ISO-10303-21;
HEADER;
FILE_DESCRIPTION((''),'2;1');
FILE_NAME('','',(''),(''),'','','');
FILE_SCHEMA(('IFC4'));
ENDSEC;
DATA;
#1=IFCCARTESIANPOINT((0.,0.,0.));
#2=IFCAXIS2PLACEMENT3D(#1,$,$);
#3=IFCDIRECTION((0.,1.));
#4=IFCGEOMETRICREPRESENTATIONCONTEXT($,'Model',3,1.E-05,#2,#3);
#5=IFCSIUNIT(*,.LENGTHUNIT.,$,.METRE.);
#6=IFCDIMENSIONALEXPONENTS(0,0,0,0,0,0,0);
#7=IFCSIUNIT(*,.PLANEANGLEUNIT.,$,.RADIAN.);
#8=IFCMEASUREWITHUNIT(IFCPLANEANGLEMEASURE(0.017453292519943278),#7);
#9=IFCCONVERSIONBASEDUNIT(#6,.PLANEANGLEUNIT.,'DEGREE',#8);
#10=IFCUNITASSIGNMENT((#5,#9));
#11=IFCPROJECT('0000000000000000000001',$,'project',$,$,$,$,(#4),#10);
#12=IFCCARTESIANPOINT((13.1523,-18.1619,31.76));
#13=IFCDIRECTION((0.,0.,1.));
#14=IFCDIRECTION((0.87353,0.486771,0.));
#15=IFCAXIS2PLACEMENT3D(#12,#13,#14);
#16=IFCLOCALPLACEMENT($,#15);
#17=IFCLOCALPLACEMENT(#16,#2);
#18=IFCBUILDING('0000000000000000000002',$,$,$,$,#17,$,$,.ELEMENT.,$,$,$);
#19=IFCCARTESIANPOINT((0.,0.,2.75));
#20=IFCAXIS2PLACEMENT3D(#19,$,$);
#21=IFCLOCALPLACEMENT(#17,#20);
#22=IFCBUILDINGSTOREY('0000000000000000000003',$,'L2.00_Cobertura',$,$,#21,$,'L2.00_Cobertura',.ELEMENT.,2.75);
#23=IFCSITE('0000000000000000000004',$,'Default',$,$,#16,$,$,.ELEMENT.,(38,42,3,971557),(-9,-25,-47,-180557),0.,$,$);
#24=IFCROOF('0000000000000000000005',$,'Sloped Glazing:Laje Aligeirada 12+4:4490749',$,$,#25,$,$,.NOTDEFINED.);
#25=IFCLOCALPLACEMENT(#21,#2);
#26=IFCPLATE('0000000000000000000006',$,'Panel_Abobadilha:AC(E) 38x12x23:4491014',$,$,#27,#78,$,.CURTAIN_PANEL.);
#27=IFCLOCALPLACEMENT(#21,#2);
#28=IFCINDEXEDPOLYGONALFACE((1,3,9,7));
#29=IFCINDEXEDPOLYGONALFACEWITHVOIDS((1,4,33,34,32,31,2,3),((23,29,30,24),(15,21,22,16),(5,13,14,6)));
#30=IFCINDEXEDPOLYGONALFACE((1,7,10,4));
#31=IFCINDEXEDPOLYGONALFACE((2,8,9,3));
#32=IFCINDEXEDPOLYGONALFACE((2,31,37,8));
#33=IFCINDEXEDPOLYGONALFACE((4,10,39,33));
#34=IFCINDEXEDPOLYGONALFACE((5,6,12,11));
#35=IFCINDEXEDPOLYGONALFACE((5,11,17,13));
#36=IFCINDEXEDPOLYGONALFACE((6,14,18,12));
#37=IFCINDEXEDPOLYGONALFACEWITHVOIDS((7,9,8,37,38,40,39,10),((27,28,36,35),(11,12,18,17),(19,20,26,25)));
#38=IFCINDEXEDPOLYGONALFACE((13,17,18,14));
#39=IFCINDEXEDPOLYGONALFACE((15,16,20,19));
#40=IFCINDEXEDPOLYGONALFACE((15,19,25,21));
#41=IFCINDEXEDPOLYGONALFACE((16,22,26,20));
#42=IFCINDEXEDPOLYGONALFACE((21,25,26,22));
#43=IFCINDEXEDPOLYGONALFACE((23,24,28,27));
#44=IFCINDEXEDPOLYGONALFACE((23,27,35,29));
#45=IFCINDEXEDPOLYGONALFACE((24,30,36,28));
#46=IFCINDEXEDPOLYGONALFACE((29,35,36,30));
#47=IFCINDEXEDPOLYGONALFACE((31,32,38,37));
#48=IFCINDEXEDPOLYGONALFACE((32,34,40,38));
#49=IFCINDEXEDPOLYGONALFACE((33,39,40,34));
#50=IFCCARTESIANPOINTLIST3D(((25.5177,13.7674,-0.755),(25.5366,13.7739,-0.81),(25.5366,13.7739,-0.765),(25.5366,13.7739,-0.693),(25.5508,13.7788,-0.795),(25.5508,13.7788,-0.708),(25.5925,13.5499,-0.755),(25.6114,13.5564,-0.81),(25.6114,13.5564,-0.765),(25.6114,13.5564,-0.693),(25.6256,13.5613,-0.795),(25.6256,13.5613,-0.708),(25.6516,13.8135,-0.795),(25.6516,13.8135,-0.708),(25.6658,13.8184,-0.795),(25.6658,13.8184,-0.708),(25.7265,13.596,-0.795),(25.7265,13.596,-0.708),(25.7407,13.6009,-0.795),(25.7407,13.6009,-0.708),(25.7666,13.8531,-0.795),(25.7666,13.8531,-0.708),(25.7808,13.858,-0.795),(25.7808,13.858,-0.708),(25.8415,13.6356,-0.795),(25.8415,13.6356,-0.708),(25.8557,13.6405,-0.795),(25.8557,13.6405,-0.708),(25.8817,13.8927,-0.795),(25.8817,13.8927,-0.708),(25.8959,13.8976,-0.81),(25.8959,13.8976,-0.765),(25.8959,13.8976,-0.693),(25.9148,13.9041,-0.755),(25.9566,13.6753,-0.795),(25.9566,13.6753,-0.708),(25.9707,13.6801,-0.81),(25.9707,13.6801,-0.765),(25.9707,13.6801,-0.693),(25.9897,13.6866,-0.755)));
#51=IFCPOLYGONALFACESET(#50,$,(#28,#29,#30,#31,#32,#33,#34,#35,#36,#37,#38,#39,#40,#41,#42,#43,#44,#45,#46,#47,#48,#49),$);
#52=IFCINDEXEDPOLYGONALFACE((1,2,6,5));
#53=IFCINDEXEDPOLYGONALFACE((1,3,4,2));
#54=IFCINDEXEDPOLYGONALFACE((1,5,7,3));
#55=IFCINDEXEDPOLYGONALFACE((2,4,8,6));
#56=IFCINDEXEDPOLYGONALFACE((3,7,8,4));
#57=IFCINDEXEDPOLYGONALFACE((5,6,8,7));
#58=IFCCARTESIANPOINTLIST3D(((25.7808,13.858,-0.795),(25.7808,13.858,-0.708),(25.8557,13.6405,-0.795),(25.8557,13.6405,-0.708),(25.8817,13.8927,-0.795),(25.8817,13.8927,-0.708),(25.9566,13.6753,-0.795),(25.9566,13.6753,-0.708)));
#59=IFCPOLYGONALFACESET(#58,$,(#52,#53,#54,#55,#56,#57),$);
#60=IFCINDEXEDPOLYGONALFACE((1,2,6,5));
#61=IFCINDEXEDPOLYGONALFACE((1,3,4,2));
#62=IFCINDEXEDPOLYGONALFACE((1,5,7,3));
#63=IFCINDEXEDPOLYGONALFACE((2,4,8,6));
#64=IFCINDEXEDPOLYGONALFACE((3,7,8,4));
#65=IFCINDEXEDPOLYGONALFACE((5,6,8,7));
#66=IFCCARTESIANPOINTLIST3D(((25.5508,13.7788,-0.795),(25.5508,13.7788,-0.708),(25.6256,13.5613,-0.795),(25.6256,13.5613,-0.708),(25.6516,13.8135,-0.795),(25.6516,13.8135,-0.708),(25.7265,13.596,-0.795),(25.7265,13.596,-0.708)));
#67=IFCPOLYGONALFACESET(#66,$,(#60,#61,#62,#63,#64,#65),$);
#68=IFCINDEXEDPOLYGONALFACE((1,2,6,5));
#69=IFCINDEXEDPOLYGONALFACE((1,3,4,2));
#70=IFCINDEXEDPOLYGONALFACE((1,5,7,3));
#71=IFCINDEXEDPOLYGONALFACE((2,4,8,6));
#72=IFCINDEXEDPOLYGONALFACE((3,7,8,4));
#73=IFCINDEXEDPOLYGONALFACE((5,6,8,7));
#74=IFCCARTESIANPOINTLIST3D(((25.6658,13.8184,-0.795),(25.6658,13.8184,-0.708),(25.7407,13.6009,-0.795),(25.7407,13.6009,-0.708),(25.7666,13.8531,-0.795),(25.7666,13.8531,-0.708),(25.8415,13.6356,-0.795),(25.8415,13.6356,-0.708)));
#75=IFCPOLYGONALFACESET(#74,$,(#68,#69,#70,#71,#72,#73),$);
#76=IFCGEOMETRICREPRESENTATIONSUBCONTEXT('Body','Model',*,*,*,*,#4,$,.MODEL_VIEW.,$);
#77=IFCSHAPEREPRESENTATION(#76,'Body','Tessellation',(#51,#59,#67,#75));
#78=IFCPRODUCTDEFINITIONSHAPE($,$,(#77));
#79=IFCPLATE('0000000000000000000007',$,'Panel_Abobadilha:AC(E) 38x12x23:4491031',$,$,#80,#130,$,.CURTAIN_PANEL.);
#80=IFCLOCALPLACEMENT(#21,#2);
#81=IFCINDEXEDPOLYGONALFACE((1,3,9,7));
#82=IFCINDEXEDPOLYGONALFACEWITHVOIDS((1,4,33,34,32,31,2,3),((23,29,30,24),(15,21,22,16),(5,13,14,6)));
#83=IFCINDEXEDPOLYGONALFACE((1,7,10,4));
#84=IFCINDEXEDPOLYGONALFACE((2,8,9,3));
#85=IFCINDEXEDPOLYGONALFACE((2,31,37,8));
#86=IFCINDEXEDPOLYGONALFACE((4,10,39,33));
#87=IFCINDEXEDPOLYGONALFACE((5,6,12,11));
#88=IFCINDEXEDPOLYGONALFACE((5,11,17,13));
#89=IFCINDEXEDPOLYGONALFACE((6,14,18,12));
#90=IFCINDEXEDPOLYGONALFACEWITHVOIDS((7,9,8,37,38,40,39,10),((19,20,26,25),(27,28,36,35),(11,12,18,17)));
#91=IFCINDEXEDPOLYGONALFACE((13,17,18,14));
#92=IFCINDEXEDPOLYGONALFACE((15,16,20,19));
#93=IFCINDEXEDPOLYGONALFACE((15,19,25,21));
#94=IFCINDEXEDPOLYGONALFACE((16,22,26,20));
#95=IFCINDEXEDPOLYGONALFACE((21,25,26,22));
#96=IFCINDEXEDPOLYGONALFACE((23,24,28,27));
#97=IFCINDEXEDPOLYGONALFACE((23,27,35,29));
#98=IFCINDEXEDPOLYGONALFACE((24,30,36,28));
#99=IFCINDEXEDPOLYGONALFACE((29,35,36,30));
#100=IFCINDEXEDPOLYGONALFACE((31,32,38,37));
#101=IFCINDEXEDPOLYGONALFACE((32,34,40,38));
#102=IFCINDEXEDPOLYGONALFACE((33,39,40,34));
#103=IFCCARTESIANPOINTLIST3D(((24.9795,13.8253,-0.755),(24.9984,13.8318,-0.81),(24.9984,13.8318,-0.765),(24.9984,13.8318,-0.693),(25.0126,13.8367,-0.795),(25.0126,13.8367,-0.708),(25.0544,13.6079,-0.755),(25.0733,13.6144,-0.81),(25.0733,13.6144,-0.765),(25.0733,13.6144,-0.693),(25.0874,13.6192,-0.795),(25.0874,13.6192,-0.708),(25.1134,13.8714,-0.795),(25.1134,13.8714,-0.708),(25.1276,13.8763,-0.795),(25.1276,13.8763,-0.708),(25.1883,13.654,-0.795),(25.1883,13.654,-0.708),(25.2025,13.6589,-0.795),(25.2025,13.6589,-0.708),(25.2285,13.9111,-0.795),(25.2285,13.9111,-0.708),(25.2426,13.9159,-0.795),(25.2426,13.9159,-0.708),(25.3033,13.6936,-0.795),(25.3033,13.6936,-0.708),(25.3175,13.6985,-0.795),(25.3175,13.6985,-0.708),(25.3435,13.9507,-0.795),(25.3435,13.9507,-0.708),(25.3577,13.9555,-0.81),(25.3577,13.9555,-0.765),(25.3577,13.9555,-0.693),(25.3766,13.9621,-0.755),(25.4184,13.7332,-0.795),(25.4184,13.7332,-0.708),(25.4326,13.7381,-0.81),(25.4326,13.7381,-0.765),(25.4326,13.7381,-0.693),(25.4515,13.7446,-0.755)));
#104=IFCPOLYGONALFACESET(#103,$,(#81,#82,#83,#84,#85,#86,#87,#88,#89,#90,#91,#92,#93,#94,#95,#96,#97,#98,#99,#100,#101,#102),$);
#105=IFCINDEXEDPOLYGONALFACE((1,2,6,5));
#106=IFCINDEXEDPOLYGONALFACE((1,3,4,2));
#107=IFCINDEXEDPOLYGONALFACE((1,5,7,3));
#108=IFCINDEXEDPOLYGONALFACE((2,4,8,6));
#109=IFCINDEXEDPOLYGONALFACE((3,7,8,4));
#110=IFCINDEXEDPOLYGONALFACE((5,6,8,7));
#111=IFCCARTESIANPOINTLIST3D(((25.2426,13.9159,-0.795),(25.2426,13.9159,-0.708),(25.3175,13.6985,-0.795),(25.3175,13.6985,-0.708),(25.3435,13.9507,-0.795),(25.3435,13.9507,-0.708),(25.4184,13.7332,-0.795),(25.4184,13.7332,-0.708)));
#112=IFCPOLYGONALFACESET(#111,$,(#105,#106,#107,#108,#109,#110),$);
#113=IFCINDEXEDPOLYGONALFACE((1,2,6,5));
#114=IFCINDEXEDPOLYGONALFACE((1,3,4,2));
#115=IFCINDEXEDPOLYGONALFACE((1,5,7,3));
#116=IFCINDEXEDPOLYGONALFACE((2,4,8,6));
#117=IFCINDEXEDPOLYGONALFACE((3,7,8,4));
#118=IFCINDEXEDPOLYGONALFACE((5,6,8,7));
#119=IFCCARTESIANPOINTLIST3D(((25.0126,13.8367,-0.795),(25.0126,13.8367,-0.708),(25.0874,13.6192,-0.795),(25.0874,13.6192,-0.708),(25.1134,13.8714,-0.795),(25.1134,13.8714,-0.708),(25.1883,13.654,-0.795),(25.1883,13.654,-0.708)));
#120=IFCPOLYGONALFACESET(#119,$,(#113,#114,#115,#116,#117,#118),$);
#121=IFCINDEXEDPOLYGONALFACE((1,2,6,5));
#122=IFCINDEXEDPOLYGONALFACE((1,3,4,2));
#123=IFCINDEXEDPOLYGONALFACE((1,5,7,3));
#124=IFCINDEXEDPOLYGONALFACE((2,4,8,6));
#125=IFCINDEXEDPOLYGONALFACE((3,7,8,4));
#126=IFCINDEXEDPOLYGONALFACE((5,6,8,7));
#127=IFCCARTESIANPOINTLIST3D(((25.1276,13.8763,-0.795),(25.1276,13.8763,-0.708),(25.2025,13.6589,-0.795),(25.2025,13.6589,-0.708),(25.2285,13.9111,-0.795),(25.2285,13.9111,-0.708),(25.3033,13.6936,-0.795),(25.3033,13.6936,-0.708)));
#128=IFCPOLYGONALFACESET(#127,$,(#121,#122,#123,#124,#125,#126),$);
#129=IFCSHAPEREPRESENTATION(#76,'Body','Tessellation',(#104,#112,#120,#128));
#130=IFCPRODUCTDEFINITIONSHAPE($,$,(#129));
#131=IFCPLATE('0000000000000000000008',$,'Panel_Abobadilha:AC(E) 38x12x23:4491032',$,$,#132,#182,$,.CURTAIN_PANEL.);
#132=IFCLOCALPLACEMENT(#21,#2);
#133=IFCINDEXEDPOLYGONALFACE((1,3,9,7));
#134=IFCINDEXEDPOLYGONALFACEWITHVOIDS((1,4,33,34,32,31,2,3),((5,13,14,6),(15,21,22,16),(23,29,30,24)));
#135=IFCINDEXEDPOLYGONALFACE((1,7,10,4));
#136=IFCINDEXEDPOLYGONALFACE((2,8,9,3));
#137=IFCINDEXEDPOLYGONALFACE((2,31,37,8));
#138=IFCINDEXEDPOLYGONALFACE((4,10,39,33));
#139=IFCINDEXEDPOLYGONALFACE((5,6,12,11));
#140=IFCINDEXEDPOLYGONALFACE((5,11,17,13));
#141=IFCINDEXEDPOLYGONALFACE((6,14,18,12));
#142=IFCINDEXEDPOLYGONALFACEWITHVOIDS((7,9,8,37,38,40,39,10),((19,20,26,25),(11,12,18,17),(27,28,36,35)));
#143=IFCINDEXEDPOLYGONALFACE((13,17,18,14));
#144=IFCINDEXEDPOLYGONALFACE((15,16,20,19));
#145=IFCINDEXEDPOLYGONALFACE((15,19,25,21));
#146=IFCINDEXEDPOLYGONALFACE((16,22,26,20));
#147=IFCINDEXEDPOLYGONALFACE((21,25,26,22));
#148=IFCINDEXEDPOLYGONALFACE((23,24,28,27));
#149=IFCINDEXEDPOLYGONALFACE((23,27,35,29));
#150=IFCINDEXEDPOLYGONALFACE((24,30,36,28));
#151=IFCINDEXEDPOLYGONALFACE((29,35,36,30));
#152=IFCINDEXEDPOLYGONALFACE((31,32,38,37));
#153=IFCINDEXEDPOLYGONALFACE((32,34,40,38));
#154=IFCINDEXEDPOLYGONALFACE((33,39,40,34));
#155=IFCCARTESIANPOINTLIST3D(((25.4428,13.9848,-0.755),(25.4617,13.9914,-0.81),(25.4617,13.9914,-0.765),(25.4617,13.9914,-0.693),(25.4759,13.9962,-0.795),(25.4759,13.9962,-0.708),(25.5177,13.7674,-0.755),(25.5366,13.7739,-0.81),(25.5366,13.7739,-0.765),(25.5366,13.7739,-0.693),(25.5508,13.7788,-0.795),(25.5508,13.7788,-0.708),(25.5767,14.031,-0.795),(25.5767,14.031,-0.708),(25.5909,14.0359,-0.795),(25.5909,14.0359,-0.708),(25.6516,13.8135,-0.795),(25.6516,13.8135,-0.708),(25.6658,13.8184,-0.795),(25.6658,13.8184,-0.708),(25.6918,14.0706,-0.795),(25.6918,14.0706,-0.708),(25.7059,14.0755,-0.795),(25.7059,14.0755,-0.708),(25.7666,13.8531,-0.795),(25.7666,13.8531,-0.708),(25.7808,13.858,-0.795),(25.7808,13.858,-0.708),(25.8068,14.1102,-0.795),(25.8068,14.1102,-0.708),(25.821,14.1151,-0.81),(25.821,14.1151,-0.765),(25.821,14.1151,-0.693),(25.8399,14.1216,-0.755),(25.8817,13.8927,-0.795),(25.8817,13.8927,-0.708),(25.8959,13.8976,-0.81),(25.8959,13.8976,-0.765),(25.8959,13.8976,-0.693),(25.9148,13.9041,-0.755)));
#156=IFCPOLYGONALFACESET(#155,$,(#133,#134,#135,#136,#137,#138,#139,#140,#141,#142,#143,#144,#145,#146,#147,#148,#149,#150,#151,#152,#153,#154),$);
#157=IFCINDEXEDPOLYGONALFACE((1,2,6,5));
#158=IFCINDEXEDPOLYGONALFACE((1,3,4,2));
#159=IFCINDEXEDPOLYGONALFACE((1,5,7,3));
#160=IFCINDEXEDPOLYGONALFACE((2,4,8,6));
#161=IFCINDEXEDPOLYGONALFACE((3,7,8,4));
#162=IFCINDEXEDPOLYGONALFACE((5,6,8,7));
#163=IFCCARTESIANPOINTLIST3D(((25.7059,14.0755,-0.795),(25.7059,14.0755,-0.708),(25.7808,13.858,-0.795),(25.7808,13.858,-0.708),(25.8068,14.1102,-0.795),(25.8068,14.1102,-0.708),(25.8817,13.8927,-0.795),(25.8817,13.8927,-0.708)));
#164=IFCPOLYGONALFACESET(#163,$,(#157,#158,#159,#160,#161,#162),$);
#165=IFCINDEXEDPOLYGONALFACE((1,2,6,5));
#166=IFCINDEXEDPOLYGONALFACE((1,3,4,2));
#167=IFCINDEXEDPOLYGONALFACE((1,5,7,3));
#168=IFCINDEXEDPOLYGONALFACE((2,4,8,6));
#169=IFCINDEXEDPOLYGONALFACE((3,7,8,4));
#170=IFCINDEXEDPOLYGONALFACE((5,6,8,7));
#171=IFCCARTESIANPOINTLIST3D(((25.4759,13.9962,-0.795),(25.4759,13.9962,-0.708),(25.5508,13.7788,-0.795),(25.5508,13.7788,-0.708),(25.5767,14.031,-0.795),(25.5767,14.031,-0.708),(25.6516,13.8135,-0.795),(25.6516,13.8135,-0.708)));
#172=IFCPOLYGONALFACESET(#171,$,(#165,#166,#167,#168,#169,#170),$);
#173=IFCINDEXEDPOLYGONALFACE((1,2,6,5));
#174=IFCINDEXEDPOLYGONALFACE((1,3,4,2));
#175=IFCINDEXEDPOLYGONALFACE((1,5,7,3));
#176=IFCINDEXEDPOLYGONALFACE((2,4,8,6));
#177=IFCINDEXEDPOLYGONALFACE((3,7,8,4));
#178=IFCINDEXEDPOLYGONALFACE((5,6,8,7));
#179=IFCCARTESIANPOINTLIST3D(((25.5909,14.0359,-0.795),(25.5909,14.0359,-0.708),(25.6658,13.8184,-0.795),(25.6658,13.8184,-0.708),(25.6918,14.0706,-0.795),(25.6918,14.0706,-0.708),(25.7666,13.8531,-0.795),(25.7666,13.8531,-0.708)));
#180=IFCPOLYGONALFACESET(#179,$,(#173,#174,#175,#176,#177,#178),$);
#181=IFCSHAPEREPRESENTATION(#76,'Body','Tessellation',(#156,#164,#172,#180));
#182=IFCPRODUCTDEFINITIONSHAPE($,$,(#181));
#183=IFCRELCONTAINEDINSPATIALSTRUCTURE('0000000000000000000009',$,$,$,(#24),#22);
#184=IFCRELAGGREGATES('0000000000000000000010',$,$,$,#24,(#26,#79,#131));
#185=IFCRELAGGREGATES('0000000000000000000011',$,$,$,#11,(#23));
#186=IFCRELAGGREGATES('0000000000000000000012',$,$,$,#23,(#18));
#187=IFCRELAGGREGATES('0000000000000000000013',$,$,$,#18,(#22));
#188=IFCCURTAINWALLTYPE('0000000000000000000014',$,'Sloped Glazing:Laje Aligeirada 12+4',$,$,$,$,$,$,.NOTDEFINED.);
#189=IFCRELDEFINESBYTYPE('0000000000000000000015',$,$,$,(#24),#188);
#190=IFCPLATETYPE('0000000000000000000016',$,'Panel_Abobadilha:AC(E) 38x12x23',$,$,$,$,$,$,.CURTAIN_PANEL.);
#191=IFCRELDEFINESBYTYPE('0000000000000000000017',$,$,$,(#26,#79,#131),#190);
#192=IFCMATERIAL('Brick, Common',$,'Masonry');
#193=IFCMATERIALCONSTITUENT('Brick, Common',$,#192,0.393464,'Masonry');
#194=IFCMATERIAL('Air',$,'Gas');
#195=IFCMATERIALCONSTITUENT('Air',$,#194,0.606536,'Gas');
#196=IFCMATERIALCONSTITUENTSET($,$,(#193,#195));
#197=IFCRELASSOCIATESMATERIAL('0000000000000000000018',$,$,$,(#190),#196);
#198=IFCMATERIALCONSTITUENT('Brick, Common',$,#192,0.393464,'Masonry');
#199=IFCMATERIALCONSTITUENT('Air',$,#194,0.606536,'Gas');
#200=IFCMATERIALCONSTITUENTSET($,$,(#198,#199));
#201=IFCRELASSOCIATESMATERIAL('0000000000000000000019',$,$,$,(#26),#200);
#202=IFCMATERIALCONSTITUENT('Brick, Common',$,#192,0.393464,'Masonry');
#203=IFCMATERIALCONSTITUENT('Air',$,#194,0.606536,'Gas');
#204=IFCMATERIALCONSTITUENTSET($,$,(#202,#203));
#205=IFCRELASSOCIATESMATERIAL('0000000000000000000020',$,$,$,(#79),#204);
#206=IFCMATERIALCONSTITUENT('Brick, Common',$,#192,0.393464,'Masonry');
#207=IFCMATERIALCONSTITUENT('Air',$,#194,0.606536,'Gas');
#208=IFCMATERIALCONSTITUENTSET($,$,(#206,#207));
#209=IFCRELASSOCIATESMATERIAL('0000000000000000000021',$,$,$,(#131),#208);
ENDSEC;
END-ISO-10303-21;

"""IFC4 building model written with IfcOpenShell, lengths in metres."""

from ifc_helpers import new_model, entity, si_unit, converted_unit, direction, frame, origin, place, context, subcontext, project, spatial, indexed_curve, outline, extrude, source, transform, mapped, material, constituent, constituent_set, type_object, type_shapes, element, aggregate, save


model = new_model("IFC4")

# Units and contexts
model_context = context("Model", 3, precision=1e-05, world=origin(), true_north=direction((0.0, 1.0)))
body_context = subcontext(model_context, "Body", "Model", "MODEL_VIEW")
ifc_project = project(units=[si_unit("LENGTHUNIT", "METRE"), converted_unit("PLANEANGLEUNIT", "DEGREE", entity("IfcPlaneAngleMeasure", 0.017453292519943278), si_unit("PLANEANGLEUNIT", "RADIAN"), dimensions=[0, 0, 0, 0, 0, 0, 0])], contexts=[model_context])

# Site, building, storey
site_placement = place(None, frame((13.1523, -18.1619, 31.76), z_axis=(0.0, 0.0, 1.0), x_axis=(0.87353, 0.486771, 0.0)))
site = spatial("IfcSite", under=ifc_project, at=site_placement, Name="Default", CompositionType="ELEMENT", RefLatitude=(38, 42, 3, 971557), RefLongitude=(-9, -25, -47, -180557), RefElevation=0.0)
building_placement = place(site_placement, origin())
building = spatial("IfcBuilding", under=site, at=building_placement, CompositionType="ELEMENT")
storey_placement = place(building_placement, frame((0.0, 0.0, 2.75)))
storey = spatial("IfcBuildingStorey", under=building, at=storey_placement, Name="L2.00_Cobertura", LongName="L2.00_Cobertura", CompositionType="ELEMENT", Elevation=2.75)

# Roof, plates
curtain_wall_type = type_object("IfcCurtainWallType", Name="Sloped Glazing:Laje Aligeirada 12+4", PredefinedType="NOTDEFINED")
roof_placement = place(storey_placement, frame((0.0, 0.0, -2.75)))
roof = element("IfcRoof", 1, at=roof_placement, inside=storey, type_object=curtain_wall_type, Name="Sloped Glazing:Laje Aligeirada 12+4:4490749", PredefinedType="NOTDEFINED")
ifc_material_1 = material(Name="Brick, Common", Category="Masonry")
ifc_material_2 = material(Name="Air", Category="Gas")
ifc_constituent_1 = constituent(ifc_material_1, Name="Brick, Common", Category="Masonry", fraction=0.393464)
ifc_constituent_2 = constituent(ifc_material_2, Name="Air", Category="Gas", fraction=0.606536)
ifc_constituent_set_1 = constituent_set(constituents=[ifc_constituent_1, ifc_constituent_2])
plate_type = type_object("IfcPlateType", Name="Panel_Abobadilha:AC(E) 38x12x23", PredefinedType="CURTAIN_PANEL", material=ifc_constituent_set_1)
shared_shape_1 = source(origin(), body_context, "Body", "SweptSolid", [
    extrude(outline(indexed_curve([(-0.19, -0.0543), (0.19, -0.0543), (0.19, -0.0093), (0.21, 0.0007), (0.19, 0.0628), (-0.19, 0.0628), (-0.21, 0.0007), (-0.19, -0.0093), (-0.19, -0.0543)], self_intersect=False), holes=[indexed_curve([(-0.0683, 0.0477), (-0.0683, -0.0393), (-0.175, -0.0393), (-0.175, 0.0477), (-0.0683, 0.0477)], self_intersect=False), indexed_curve([(0.0533, 0.0477), (0.0533, -0.0393), (-0.0533, -0.0393), (-0.0533, 0.0477), (0.0533, 0.0477)], self_intersect=False), indexed_curve([(0.175, 0.0477), (0.175, -0.0393), (0.0683, -0.0393), (0.0683, 0.0477), (0.175, 0.0477)], self_intersect=False)]), frame((0.0, 0.0543, 0.0)), (0.0, 0.0, 1.0), 0.23),
    extrude(outline(indexed_curve([(-0.0533, -0.0435), (0.0533, -0.0435), (0.0533, 0.0435), (-0.0533, 0.0435), (-0.0533, -0.0435)], self_intersect=False)), frame((0.1217, 0.0585, 0.0), z_axis=(0.0, 0.0, 1.0), x_axis=(-1.0, 0.0, 0.0)), (0.0, 0.0, 1.0), 0.23),
    extrude(outline(indexed_curve([(-0.0533, -0.0435), (0.0533, -0.0435), (0.0533, 0.0435), (-0.0533, 0.0435), (-0.0533, -0.0435)], self_intersect=False)), frame((-0.1217, 0.0585, 0.0), z_axis=(0.0, 0.0, 1.0), x_axis=(-1.0, 0.0, 0.0)), (0.0, 0.0, 1.0), 0.23),
    extrude(outline(indexed_curve([(-0.0533, -0.0435), (0.0533, -0.0435), (0.0533, 0.0435), (-0.0533, 0.0435), (-0.0533, -0.0435)], self_intersect=False)), frame((0.0, 0.0585, 0.0), z_axis=(0.0, 0.0, 1.0), x_axis=(-1.0, 0.0, 0.0)), (0.0, 0.0, 1.0), 0.23),
])
type_shapes(plate_type, [shared_shape_1])
ifc_constituent_3 = constituent(ifc_material_1, Name="Brick, Common", Category="Masonry", fraction=0.393464)
ifc_constituent_4 = constituent(ifc_material_2, Name="Air", Category="Gas", fraction=0.606536)
ifc_constituent_set_2 = constituent_set(constituents=[ifc_constituent_3, ifc_constituent_4])
plate_1_placement = place(roof_placement, frame((25.7162, 13.8357, 1.94), z_axis=(0.325568, -0.945519, 0.0), x_axis=(0.945519, 0.325568, 0.0)))
plate_1 = element("IfcPlate", 2, at=plate_1_placement, type_object=plate_type, material=ifc_constituent_set_2, Name="Panel_Abobadilha:AC(E) 38x12x23:4491014", PredefinedType="CURTAIN_PANEL", context=body_context, shape_type="MappedRepresentation", body=[
    mapped(shared_shape_1, transform((0.0, 0.0, 0.0), scale=1.0)),
])
ifc_constituent_5 = constituent(ifc_material_1, Name="Brick, Common", Category="Masonry", fraction=0.393464)
ifc_constituent_6 = constituent(ifc_material_2, Name="Air", Category="Gas", fraction=0.606536)
ifc_constituent_set_3 = constituent_set(constituents=[ifc_constituent_5, ifc_constituent_6])
plate_2_placement = place(roof_placement, frame((25.178, 13.8937, 1.94), z_axis=(0.325568, -0.945519, 0.0), x_axis=(0.945519, 0.325568, 0.0)))
plate_2 = element("IfcPlate", 3, at=plate_2_placement, type_object=plate_type, material=ifc_constituent_set_3, Name="Panel_Abobadilha:AC(E) 38x12x23:4491031", PredefinedType="CURTAIN_PANEL", context=body_context, shape_type="MappedRepresentation", body=[
    mapped(shared_shape_1, transform((0.0, 0.0, 0.0), scale=1.0)),
])
ifc_constituent_7 = constituent(ifc_material_1, Name="Brick, Common", Category="Masonry", fraction=0.393464)
ifc_constituent_8 = constituent(ifc_material_2, Name="Air", Category="Gas", fraction=0.606536)
ifc_constituent_set_4 = constituent_set(constituents=[ifc_constituent_7, ifc_constituent_8])
plate_3_placement = place(roof_placement, frame((25.6413, 14.0532, 1.94), z_axis=(0.325568, -0.945519, 0.0), x_axis=(0.945519, 0.325568, 0.0)))
plate_3 = element("IfcPlate", 4, at=plate_3_placement, type_object=plate_type, material=ifc_constituent_set_4, Name="Panel_Abobadilha:AC(E) 38x12x23:4491032", PredefinedType="CURTAIN_PANEL", context=body_context, shape_type="MappedRepresentation", body=[
    mapped(shared_shape_1, transform((0.0, 0.0, 0.0), scale=1.0)),
])
aggregate(roof, [plate_1, plate_2, plate_3])

save(model, "model.ifc")
